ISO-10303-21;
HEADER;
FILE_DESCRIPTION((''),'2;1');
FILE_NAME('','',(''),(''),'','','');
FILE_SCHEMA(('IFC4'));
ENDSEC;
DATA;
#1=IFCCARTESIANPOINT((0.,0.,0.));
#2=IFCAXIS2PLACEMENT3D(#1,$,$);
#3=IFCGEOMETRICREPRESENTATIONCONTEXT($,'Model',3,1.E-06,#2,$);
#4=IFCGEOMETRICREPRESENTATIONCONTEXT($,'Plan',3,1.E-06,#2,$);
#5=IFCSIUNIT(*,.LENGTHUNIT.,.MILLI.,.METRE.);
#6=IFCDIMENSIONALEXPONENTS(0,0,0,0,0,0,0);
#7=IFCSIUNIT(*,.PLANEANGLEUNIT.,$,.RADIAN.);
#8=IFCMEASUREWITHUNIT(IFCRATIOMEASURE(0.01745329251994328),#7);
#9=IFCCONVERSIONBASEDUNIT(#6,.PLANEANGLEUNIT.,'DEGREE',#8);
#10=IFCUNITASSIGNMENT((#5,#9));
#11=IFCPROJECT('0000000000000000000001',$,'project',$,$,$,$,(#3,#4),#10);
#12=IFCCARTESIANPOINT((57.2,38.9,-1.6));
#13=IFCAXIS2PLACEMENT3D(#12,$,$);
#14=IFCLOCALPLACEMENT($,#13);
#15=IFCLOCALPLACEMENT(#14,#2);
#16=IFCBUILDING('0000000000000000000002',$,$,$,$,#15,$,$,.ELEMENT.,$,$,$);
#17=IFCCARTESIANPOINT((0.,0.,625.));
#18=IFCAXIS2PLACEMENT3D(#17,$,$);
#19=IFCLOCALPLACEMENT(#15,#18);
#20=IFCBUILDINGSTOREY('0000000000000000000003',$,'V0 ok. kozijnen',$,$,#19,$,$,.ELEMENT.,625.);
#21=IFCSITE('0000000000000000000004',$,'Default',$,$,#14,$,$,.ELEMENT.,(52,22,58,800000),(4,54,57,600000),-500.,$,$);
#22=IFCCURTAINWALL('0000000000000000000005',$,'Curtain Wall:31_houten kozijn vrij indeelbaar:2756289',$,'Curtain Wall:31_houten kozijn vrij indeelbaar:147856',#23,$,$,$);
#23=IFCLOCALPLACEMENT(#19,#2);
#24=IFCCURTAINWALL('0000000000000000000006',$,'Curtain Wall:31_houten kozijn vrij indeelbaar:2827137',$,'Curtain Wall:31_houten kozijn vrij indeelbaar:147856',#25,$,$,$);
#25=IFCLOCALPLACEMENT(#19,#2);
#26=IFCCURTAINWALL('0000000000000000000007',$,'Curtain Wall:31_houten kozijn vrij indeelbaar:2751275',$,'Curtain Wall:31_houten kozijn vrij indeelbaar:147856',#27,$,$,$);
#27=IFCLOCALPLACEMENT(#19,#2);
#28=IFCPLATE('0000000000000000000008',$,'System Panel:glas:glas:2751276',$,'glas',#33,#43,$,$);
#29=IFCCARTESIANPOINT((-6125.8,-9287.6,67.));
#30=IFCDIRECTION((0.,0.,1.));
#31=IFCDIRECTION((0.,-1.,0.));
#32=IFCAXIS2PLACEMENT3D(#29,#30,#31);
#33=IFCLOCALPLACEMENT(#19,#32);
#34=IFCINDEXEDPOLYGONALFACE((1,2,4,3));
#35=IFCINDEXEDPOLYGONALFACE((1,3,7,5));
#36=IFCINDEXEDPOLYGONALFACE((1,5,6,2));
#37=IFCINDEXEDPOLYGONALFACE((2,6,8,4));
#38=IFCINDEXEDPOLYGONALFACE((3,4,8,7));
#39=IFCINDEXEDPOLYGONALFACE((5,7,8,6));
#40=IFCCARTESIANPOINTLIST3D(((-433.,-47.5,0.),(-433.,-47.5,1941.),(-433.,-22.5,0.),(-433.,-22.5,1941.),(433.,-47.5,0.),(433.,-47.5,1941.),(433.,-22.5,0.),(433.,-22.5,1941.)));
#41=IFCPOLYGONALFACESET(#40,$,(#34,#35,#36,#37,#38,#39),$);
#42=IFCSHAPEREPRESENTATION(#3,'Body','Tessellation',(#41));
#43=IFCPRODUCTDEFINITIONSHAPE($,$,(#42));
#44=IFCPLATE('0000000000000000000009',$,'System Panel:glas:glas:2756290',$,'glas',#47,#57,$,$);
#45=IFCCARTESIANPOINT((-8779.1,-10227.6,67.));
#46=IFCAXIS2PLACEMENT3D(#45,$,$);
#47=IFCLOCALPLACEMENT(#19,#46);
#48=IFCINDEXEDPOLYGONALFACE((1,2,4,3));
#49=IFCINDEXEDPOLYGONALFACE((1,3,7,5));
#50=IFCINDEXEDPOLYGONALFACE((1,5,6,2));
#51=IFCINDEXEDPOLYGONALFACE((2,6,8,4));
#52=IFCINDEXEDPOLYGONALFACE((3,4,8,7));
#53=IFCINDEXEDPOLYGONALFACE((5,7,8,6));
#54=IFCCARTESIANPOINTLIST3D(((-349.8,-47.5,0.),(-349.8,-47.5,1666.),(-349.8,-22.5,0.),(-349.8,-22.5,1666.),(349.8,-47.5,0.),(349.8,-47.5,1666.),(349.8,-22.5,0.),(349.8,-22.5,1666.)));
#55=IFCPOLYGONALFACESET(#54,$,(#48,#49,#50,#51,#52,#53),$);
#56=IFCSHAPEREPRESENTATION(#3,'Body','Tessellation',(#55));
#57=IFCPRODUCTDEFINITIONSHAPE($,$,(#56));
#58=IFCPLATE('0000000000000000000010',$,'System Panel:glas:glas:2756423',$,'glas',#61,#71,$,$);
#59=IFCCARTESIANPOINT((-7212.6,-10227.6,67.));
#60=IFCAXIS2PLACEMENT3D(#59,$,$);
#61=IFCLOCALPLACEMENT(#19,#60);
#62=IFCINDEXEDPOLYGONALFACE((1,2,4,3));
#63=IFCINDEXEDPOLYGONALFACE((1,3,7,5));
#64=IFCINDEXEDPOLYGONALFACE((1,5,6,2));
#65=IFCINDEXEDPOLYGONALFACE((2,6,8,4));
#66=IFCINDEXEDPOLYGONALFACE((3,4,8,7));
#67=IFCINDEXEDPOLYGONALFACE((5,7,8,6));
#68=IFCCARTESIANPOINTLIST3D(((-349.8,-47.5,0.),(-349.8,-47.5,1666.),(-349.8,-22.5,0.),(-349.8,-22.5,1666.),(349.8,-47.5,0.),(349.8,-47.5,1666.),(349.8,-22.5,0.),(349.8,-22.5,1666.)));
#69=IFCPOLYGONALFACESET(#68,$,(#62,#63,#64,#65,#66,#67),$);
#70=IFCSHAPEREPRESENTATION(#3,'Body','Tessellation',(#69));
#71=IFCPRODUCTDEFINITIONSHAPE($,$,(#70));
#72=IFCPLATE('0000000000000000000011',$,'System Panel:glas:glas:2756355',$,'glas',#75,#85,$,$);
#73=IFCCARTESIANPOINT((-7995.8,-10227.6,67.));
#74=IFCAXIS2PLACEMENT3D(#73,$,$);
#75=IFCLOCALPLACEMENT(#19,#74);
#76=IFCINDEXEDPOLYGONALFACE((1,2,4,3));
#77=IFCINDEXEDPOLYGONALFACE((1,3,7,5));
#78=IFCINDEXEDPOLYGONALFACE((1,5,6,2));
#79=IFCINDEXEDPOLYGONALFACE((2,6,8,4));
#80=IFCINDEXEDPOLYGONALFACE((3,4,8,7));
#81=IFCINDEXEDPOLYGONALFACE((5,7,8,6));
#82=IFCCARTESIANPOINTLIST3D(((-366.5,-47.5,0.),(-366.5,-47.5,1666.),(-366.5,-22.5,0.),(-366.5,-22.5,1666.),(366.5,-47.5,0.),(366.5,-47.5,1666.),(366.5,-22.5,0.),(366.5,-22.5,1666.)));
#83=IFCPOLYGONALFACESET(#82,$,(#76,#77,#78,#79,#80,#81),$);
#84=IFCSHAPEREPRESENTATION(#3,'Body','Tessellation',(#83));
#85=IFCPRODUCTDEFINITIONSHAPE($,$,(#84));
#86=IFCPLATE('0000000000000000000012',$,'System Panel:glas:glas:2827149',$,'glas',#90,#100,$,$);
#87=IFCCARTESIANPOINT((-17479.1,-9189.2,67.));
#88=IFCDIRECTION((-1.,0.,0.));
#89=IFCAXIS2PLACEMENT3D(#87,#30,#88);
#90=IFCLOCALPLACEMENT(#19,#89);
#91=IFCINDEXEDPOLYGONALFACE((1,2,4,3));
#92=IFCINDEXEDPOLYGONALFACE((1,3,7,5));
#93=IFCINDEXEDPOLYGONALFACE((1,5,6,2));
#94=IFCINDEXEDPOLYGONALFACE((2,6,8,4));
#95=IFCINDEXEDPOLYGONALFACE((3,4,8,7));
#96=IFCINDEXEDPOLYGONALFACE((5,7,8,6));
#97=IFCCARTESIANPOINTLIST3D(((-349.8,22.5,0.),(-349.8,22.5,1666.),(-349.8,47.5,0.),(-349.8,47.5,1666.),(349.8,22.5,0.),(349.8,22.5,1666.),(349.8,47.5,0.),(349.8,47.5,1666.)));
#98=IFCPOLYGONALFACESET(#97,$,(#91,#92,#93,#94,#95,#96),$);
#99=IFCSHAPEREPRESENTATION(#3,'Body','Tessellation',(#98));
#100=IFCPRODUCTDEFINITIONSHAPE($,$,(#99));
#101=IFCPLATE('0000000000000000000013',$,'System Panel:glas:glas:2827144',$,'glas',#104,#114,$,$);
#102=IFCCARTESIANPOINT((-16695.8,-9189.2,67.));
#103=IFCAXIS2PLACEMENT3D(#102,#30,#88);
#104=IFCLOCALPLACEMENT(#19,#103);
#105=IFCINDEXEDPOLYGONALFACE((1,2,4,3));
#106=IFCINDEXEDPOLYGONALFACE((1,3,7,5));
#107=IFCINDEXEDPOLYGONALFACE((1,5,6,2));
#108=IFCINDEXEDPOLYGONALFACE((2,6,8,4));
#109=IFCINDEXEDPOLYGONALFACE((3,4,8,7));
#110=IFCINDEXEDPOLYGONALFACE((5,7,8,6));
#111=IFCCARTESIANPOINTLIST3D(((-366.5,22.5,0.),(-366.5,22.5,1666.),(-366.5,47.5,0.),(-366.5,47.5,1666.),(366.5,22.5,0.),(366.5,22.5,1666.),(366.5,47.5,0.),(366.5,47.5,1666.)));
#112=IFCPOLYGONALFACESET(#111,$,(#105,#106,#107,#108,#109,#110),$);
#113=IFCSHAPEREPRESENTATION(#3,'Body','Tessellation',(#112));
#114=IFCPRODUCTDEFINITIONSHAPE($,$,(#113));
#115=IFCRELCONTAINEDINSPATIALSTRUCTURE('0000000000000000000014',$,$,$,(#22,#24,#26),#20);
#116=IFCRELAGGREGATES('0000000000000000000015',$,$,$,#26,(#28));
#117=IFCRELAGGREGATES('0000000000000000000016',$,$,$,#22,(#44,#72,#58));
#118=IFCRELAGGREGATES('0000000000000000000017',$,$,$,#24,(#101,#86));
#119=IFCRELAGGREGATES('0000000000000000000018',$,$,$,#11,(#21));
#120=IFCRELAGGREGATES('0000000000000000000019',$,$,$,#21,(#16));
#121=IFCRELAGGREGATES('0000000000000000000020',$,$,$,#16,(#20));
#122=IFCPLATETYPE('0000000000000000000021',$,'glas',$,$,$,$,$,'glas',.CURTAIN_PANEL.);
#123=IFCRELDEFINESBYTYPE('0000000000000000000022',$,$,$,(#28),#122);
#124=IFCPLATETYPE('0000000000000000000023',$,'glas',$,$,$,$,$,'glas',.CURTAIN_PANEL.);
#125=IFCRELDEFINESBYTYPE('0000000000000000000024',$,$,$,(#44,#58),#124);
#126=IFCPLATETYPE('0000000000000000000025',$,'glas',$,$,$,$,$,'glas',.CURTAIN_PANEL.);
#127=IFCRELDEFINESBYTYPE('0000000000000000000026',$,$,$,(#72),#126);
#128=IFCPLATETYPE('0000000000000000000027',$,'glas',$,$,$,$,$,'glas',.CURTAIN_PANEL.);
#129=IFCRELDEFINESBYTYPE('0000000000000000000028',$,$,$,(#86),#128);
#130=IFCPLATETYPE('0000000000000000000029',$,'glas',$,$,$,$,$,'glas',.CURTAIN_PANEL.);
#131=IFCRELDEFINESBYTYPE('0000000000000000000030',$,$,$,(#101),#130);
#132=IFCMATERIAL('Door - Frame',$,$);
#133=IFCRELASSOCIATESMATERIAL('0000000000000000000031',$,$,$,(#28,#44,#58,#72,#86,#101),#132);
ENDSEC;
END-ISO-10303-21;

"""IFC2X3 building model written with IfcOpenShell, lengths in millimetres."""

from ifc_helpers import new_model, entity, si_unit, converted_unit, frame, origin, origin_2d_with_axis, place, context, project, spatial, rectangle, extrude, source, transform, mapped, material, type_object, type_shapes, element, aggregate, save


model = new_model("IFC2X3")

# Units and contexts
model_context = context("Model", 3, precision=1e-06, world=origin())
plan_context = context("Plan", 3, precision=1e-06, world=origin())
ifc_project = project(units=[si_unit("LENGTHUNIT", "METRE", prefix="MILLI"), converted_unit("PLANEANGLEUNIT", "DEGREE", entity("IfcRatioMeasure", 0.01745329251994328), si_unit("PLANEANGLEUNIT", "RADIAN"), dimensions=[0, 0, 0, 0, 0, 0, 0])], contexts=[model_context, plan_context])

# Site, building, storey
site_placement = place(None, frame((57.2, 38.9, -1.6)))
site = spatial("IfcSite", under=ifc_project, at=site_placement, Name="Default", CompositionType="ELEMENT", RefLatitude=(52, 22, 58, 800000), RefLongitude=(4, 54, 57, 600000), RefElevation=-500.0)
building_placement = place(site_placement, origin())
building = spatial("IfcBuilding", under=site, at=building_placement, CompositionType="ELEMENT")
storey_placement = place(building_placement, frame((0.0, 0.0, 625.0)))
storey = spatial("IfcBuildingStorey", under=building, at=storey_placement, Name="V0 ok. kozijnen", CompositionType="ELEMENT", Elevation=625.0)

# Curtain walls
curtain_wall_1_placement = place(storey_placement, origin())
curtain_wall_1 = element("IfcCurtainWall", 1, at=curtain_wall_1_placement, inside=storey, Name="Curtain Wall:31_houten kozijn vrij indeelbaar:2756289", ObjectType="Curtain Wall:31_houten kozijn vrij indeelbaar:147856")
curtain_wall_2_placement = place(storey_placement, origin())
curtain_wall_2 = element("IfcCurtainWall", 2, at=curtain_wall_2_placement, inside=storey, Name="Curtain Wall:31_houten kozijn vrij indeelbaar:2827137", ObjectType="Curtain Wall:31_houten kozijn vrij indeelbaar:147856")

# Curtain wall, plate
curtain_wall_3_placement = place(storey_placement, origin())
curtain_wall_3 = element("IfcCurtainWall", 3, at=curtain_wall_3_placement, inside=storey, Name="Curtain Wall:31_houten kozijn vrij indeelbaar:2751275", ObjectType="Curtain Wall:31_houten kozijn vrij indeelbaar:147856")
ifc_material_1 = material(Name="Door - Frame")
plate_type_1 = type_object("IfcPlateType", Name="glas", ElementType="glas", PredefinedType="CURTAIN_PANEL")
shared_shape_1 = source(origin(), model_context, "Body", "SweptSolid", [
    extrude(rectangle(XDim=25.0, YDim=866.0, at=origin_2d_with_axis()), frame((0.0, -35.0, 0.0), z_axis=(0.0, 0.0, 1.0), x_axis=(0.0, 1.0, 0.0)), (0.0, 0.0, 1.0), 1941.0),
])
type_shapes(plate_type_1, [shared_shape_1])
plate_1_placement = place(storey_placement, frame((-6125.8, -9287.6, 67.0), z_axis=(0.0, 0.0, 1.0), x_axis=(0.0, -1.0, 0.0)))
plate_1 = element("IfcPlate", 4, at=plate_1_placement, type_object=plate_type_1, material=ifc_material_1, Name="System Panel:glas:glas:2751276", ObjectType="glas", context=model_context, shape_type="MappedRepresentation", body=[
    mapped(shared_shape_1, transform((0.0, 0.0, 0.0), scale=1.0)),
])
aggregate(curtain_wall_3, [plate_1])

# Plates
plate_type_2 = type_object("IfcPlateType", Name="glas", ElementType="glas", PredefinedType="CURTAIN_PANEL")
shared_shape_2 = source(origin(), model_context, "Body", "SweptSolid", [
    extrude(rectangle(XDim=25.0, YDim=699.5, at=origin_2d_with_axis()), frame((0.0, -35.0, 0.0), z_axis=(0.0, 0.0, 1.0), x_axis=(0.0, 1.0, 0.0)), (0.0, 0.0, 1.0), 1666.0),
])
type_shapes(plate_type_2, [shared_shape_2])
plate_2_placement = place(storey_placement, frame((-8779.1, -10227.6, 67.0)))
plate_2 = element("IfcPlate", 5, at=plate_2_placement, type_object=plate_type_2, material=ifc_material_1, Name="System Panel:glas:glas:2756290", ObjectType="glas", context=model_context, shape_type="MappedRepresentation", body=[
    mapped(shared_shape_2, transform((0.0, 0.0, 0.0), scale=1.0)),
])
plate_3_placement = place(storey_placement, frame((-7212.6, -10227.6, 67.0)))
plate_3 = element("IfcPlate", 6, at=plate_3_placement, type_object=plate_type_2, material=ifc_material_1, Name="System Panel:glas:glas:2756423", ObjectType="glas", context=model_context, shape_type="MappedRepresentation", body=[
    mapped(shared_shape_2, transform((0.0, 0.0, 0.0), scale=1.0)),
])
plate_type_3 = type_object("IfcPlateType", Name="glas", ElementType="glas", PredefinedType="CURTAIN_PANEL")
shared_shape_3 = source(origin(), model_context, "Body", "SweptSolid", [
    extrude(rectangle(XDim=25.0, YDim=733.0, at=origin_2d_with_axis()), frame((0.0, -35.0, 0.0), z_axis=(0.0, 0.0, 1.0), x_axis=(0.0, 1.0, 0.0)), (0.0, 0.0, 1.0), 1666.0),
])
type_shapes(plate_type_3, [shared_shape_3])
plate_4_placement = place(storey_placement, frame((-7995.8, -10227.6, 67.0)))
plate_4 = element("IfcPlate", 7, at=plate_4_placement, type_object=plate_type_3, material=ifc_material_1, Name="System Panel:glas:glas:2756355", ObjectType="glas", context=model_context, shape_type="MappedRepresentation", body=[
    mapped(shared_shape_3, transform((0.0, 0.0, 0.0), scale=1.0)),
])
aggregate(curtain_wall_1, [plate_2, plate_4, plate_3])
plate_type_4 = type_object("IfcPlateType", Name="glas", ElementType="glas", PredefinedType="CURTAIN_PANEL")
shared_shape_4 = source(origin(), model_context, "Body", "SweptSolid", [
    extrude(rectangle(XDim=25.0, YDim=699.5, at=origin_2d_with_axis()), frame((0.0, 35.0, 0.0), z_axis=(0.0, 0.0, 1.0), x_axis=(0.0, 1.0, 0.0)), (0.0, 0.0, 1.0), 1666.0),
])
type_shapes(plate_type_4, [shared_shape_4])
plate_5_placement = place(storey_placement, frame((-17479.1, -9189.2, 67.0), z_axis=(0.0, 0.0, 1.0), x_axis=(-1.0, 0.0, 0.0)))
plate_5 = element("IfcPlate", 8, at=plate_5_placement, type_object=plate_type_4, material=ifc_material_1, Name="System Panel:glas:glas:2827149", ObjectType="glas", context=model_context, shape_type="MappedRepresentation", body=[
    mapped(shared_shape_4, transform((0.0, 0.0, 0.0), scale=1.0)),
])
plate_type_5 = type_object("IfcPlateType", Name="glas", ElementType="glas", PredefinedType="CURTAIN_PANEL")
shared_shape_5 = source(origin(), model_context, "Body", "SweptSolid", [
    extrude(rectangle(XDim=25.0, YDim=733.0, at=origin_2d_with_axis()), frame((0.0, 35.0, 0.0), z_axis=(0.0, 0.0, 1.0), x_axis=(0.0, 1.0, 0.0)), (0.0, 0.0, 1.0), 1666.0),
])
type_shapes(plate_type_5, [shared_shape_5])
plate_6_placement = place(storey_placement, frame((-16695.8, -9189.2, 67.0), z_axis=(0.0, 0.0, 1.0), x_axis=(-1.0, 0.0, 0.0)))
plate_6 = element("IfcPlate", 9, at=plate_6_placement, type_object=plate_type_5, material=ifc_material_1, Name="System Panel:glas:glas:2827144", ObjectType="glas", context=model_context, shape_type="MappedRepresentation", body=[
    mapped(shared_shape_5, transform((0.0, 0.0, 0.0), scale=1.0)),
])
aggregate(curtain_wall_2, [plate_6, plate_5])

save(model, "model.ifc")
